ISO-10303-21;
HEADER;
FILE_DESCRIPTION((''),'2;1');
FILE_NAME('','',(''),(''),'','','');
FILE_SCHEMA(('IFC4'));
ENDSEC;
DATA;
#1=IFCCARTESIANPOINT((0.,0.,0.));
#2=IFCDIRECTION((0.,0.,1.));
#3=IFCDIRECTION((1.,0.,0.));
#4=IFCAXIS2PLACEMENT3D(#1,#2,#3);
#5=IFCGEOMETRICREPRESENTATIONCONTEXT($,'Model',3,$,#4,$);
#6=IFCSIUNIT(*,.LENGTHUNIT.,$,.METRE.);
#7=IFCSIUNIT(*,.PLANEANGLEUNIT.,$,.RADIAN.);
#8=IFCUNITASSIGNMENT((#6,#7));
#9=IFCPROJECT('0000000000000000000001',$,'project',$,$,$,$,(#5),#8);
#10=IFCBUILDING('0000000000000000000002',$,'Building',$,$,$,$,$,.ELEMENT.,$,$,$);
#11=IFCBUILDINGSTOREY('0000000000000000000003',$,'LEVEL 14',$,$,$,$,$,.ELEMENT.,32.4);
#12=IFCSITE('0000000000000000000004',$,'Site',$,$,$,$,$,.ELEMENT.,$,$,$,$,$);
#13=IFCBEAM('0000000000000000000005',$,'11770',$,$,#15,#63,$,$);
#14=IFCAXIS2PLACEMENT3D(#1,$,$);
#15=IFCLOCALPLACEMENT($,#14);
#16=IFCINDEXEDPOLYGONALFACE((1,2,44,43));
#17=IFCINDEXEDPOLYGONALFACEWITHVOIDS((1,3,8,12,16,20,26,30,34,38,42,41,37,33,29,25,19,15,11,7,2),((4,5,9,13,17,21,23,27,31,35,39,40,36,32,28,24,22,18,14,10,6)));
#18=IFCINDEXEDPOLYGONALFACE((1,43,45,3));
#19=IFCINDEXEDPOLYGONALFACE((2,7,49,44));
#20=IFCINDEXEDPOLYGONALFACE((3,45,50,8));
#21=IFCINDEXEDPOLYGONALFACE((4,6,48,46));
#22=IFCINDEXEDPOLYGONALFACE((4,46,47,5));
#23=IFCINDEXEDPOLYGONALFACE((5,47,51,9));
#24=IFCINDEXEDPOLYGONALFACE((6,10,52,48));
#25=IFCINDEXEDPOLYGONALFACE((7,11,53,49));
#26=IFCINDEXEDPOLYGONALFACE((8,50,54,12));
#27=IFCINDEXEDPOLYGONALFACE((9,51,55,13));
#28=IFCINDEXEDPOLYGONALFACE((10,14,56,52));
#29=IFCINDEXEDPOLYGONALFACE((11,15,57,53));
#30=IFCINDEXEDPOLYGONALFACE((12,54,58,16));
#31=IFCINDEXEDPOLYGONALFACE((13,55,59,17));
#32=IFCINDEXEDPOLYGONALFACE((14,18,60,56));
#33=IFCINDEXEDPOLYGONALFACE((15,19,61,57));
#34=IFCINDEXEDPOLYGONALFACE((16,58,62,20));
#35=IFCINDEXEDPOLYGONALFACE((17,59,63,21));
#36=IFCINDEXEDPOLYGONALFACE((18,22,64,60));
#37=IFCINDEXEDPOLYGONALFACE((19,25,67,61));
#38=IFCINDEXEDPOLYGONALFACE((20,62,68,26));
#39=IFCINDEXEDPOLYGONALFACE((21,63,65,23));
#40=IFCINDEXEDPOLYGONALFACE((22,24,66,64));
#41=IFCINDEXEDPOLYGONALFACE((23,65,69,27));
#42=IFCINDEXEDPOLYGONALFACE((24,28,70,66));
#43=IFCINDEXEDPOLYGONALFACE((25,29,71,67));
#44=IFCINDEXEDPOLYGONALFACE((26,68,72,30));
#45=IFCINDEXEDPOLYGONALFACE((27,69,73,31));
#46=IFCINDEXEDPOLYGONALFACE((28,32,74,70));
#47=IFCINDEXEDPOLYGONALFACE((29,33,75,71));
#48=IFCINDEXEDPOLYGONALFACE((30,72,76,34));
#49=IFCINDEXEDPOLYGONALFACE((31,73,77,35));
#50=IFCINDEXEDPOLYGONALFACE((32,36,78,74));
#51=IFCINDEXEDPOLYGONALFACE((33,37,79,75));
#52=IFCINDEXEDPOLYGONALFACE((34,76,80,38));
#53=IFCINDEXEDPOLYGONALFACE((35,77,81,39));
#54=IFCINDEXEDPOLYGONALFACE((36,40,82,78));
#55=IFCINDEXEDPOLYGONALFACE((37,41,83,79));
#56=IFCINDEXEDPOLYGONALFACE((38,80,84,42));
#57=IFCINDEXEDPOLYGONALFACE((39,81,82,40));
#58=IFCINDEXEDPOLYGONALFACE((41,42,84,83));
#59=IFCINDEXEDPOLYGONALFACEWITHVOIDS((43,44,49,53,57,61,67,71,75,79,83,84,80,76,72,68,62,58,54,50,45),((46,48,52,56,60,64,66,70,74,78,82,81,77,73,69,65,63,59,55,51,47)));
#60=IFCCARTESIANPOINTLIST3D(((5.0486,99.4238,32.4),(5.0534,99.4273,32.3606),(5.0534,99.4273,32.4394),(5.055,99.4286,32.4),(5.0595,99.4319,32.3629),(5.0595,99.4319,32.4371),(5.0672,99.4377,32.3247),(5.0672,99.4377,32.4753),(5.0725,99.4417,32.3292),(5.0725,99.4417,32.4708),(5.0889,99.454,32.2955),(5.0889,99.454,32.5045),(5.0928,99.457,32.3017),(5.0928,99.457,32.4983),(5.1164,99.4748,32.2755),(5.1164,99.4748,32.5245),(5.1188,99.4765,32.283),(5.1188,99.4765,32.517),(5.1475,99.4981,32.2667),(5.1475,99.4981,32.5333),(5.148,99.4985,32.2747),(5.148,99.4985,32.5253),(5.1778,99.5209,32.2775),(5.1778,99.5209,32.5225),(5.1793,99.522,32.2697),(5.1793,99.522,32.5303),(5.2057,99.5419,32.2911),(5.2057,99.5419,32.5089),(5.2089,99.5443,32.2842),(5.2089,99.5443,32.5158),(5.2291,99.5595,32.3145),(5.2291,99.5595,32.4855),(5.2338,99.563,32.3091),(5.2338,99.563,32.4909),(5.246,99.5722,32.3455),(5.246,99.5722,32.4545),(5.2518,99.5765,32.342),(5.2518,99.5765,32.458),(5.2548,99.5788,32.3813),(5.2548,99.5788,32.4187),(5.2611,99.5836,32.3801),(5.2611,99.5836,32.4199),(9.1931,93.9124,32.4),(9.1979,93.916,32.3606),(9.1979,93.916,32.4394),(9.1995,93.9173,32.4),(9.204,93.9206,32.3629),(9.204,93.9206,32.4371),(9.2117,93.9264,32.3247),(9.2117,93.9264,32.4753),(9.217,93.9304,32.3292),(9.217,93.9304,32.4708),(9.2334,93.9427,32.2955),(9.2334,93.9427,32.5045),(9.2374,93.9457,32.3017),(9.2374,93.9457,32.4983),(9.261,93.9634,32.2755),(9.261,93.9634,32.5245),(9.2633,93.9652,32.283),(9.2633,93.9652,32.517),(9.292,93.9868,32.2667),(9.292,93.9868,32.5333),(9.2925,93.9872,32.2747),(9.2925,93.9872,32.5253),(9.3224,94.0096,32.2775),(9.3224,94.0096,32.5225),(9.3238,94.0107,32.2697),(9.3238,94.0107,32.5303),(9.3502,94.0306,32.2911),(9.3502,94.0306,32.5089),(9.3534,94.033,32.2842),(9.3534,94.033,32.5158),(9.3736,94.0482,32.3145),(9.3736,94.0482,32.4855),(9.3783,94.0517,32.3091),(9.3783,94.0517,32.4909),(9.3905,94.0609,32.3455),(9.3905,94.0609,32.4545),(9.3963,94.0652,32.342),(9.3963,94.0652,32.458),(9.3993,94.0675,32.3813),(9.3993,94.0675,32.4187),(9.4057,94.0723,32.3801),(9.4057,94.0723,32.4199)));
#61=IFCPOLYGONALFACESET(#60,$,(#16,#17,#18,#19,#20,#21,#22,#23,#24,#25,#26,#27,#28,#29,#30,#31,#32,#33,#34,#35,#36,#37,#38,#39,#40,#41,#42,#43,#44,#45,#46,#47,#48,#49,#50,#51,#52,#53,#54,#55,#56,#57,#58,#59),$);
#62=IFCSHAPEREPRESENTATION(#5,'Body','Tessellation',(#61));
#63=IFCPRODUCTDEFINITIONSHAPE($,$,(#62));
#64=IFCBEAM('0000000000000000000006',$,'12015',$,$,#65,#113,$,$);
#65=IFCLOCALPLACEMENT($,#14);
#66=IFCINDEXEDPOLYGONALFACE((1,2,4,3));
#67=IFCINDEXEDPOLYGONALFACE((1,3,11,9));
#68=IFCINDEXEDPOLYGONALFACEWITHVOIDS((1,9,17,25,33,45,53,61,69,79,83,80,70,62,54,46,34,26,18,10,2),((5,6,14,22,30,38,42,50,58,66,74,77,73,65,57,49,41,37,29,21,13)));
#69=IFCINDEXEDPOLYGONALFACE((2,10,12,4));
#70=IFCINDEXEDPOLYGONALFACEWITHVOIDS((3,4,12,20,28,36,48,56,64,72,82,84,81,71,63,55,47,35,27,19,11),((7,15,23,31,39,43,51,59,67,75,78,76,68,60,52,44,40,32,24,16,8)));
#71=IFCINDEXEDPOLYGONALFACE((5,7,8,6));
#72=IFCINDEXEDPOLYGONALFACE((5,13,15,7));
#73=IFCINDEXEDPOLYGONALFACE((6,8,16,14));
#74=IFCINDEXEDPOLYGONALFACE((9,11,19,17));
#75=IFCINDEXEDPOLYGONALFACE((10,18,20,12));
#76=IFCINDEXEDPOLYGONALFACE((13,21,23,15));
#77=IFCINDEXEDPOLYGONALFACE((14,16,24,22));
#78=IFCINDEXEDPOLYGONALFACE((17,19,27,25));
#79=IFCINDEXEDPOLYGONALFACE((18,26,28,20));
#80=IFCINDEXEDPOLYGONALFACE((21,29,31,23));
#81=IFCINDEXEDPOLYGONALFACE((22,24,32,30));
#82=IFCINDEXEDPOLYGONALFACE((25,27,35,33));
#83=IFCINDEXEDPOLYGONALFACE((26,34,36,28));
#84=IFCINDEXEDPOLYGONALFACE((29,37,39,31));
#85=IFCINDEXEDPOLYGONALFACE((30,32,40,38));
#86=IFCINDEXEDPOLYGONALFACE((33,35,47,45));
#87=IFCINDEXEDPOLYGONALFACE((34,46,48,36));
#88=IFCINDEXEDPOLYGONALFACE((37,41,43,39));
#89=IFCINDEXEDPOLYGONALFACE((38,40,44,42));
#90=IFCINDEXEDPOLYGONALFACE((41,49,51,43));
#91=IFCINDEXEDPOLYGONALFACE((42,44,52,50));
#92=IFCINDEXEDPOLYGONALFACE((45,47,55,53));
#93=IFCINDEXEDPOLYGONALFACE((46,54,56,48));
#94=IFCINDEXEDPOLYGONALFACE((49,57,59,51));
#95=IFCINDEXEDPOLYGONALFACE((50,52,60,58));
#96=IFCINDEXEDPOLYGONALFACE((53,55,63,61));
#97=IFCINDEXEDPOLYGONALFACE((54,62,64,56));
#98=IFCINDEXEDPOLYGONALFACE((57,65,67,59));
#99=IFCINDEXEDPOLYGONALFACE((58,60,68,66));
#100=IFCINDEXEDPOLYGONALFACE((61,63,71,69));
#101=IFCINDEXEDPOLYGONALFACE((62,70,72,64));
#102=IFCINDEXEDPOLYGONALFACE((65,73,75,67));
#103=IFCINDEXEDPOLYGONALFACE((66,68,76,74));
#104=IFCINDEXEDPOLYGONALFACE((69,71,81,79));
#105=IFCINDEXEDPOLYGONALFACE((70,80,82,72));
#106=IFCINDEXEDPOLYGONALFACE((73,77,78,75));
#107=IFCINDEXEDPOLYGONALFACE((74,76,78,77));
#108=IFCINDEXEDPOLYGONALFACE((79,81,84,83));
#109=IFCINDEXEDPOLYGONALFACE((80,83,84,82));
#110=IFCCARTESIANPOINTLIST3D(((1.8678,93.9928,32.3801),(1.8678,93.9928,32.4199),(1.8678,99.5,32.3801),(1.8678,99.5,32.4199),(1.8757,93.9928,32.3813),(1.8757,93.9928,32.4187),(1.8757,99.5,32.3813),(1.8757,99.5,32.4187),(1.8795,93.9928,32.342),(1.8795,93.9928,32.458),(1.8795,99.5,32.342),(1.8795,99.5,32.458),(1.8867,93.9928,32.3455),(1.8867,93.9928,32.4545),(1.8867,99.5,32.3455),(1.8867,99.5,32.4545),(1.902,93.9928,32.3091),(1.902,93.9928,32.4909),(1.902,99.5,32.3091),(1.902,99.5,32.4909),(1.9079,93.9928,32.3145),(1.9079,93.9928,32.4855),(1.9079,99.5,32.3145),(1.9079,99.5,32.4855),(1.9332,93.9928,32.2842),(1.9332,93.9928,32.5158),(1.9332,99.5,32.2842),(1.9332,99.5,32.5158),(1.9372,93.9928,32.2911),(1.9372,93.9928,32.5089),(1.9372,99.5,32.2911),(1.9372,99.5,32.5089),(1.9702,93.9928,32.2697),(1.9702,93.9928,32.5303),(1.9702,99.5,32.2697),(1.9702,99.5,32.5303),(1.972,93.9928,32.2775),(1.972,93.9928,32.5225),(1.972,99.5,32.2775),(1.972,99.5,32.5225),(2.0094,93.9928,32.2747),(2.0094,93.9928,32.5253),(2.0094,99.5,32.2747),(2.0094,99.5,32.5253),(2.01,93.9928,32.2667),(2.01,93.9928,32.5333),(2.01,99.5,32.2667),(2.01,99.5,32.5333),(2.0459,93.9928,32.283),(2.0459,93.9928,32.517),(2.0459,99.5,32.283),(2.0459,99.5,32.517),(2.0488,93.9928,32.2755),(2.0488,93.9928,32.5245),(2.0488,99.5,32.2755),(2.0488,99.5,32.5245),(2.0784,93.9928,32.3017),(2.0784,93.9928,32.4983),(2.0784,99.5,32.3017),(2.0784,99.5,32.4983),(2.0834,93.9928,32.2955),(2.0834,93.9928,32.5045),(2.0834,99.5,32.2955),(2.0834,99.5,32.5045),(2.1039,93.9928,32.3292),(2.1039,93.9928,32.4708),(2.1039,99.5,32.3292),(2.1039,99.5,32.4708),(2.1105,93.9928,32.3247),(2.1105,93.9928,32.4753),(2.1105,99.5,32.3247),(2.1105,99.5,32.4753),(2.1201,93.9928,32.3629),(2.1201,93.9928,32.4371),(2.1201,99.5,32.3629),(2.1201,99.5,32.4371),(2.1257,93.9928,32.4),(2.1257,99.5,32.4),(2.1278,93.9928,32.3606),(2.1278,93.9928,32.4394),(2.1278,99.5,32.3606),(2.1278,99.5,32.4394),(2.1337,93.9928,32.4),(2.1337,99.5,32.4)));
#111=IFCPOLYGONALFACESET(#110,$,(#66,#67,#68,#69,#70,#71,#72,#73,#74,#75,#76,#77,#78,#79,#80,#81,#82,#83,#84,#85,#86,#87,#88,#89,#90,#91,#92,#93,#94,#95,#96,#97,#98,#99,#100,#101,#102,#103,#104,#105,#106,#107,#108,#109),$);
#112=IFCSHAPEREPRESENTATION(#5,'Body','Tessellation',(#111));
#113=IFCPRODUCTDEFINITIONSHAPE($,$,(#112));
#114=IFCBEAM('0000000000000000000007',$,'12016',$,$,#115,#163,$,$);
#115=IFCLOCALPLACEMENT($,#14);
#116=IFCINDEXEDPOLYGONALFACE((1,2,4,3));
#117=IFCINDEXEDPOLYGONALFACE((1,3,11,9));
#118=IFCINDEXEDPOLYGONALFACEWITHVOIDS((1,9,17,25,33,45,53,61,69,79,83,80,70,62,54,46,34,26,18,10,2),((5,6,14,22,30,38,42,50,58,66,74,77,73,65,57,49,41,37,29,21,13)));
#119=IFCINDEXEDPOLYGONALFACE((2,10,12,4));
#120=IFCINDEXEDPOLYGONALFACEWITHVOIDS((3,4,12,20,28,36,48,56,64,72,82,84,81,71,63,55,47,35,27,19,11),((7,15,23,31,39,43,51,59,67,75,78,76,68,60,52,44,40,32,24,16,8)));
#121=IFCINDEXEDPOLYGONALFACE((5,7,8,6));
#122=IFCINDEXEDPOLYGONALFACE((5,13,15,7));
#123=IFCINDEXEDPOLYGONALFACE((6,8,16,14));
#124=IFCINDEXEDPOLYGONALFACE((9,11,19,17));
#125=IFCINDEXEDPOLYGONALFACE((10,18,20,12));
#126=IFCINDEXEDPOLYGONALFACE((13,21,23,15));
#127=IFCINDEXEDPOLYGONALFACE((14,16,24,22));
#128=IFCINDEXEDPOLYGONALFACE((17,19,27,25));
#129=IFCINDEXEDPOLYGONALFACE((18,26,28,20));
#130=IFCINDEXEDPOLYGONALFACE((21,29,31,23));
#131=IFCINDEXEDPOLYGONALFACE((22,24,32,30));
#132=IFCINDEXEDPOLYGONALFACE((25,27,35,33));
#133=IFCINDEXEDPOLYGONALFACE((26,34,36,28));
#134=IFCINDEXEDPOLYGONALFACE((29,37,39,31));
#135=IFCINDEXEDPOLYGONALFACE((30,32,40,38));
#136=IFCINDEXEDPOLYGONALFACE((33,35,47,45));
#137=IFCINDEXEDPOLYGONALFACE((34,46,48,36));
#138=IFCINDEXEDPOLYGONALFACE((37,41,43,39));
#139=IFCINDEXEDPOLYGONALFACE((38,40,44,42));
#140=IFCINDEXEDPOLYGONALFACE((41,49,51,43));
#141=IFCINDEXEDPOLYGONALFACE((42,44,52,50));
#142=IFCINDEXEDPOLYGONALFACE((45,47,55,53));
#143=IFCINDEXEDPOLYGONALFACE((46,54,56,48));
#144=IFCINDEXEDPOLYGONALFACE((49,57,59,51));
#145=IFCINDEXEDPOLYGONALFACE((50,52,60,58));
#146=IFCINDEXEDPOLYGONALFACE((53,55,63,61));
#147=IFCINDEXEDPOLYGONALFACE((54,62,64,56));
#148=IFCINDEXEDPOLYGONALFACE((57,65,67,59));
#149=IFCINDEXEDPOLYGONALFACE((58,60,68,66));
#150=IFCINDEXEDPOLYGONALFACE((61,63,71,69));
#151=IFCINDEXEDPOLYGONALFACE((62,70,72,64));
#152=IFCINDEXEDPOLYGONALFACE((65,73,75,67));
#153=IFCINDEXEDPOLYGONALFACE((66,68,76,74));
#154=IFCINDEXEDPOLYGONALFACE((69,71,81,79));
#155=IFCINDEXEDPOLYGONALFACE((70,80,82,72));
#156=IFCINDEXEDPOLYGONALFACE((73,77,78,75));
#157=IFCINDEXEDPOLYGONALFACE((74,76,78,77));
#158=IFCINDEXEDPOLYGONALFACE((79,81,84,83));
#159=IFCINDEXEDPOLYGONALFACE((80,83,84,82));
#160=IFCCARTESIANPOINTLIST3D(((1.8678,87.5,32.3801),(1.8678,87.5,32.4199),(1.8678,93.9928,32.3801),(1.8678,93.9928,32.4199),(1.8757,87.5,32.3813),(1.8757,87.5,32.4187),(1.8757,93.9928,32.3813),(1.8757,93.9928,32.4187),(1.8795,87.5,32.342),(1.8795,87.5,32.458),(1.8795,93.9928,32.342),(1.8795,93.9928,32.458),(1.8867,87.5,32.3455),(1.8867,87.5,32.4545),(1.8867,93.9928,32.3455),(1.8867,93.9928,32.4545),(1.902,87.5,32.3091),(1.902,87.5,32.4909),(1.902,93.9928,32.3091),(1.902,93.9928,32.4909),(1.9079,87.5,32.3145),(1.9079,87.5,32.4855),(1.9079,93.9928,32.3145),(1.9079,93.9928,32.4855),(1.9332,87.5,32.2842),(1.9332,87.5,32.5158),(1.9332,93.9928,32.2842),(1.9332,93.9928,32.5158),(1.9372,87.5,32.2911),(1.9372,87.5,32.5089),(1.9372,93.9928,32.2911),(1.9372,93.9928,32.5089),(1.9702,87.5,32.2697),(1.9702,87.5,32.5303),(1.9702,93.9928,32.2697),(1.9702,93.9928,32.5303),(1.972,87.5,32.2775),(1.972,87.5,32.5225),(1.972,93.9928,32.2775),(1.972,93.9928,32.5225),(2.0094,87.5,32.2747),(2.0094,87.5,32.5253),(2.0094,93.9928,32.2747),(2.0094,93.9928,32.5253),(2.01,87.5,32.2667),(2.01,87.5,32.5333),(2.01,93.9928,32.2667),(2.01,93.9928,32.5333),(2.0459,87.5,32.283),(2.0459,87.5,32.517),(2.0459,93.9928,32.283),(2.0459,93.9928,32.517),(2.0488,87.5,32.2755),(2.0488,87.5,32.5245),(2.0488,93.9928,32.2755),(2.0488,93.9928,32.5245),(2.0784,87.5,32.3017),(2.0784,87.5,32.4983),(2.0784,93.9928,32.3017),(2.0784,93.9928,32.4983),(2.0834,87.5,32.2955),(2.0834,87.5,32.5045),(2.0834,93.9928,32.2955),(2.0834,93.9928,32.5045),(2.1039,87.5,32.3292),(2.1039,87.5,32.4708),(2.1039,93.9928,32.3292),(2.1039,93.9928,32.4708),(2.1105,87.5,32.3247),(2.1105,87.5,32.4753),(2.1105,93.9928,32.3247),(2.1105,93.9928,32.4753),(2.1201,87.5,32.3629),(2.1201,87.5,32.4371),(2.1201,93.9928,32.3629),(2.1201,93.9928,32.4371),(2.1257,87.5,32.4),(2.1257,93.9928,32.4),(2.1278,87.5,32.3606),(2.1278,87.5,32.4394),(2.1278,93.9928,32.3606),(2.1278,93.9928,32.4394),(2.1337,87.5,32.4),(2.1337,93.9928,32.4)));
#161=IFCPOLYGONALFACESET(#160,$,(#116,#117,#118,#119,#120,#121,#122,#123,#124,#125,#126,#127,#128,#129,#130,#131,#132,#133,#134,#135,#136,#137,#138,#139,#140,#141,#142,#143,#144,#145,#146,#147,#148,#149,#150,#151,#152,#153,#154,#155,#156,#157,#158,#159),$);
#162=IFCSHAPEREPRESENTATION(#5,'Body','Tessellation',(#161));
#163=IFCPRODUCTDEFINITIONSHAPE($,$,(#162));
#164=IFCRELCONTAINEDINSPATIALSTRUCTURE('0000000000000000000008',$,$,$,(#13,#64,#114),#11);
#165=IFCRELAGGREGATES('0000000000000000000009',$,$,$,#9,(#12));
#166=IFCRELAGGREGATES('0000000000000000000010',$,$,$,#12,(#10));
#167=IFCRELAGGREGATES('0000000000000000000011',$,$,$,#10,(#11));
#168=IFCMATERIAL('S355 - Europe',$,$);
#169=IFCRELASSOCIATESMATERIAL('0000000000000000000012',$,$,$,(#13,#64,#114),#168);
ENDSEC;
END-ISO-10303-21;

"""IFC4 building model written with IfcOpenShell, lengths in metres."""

from ifc_helpers import new_model, si_unit, frame, origin_with_axes, origin_2d_with_axis, place, context, project, spatial, hollow_circle, extrude, material, material_profile, profile_set, profile_usage, element, save


model = new_model("IFC4")

# Units and contexts
model_context = context("Model", 3, world=origin_with_axes())
ifc_project = project(units=[si_unit("LENGTHUNIT", "METRE"), si_unit("PLANEANGLEUNIT", "RADIAN")], contexts=[model_context])

# Site, building, storey
site = spatial("IfcSite", under=ifc_project, Name="Site", CompositionType="ELEMENT")
building = spatial("IfcBuilding", under=site, Name="Building", CompositionType="ELEMENT")
storey = spatial("IfcBuildingStorey", under=building, Name="LEVEL 14", CompositionType="ELEMENT", Elevation=32.4)

# Shared definitions
ifc_material = material(Name="S355 - Europe")

# Beams
ifc_material_profile_1 = material_profile(ifc_material, hollow_circle(Radius=0.1337, WallThickness=0.008, at=origin_2d_with_axis()))
ifc_profile_set_1 = profile_set([ifc_material_profile_1])
ifc_profile_usage_1 = profile_usage(ifc_profile_set_1, cardinal=10)
beam_1_placement = place(None, frame((9.3, 93.9928, 32.4), z_axis=(-0.601023, 0.799232, 0.0), x_axis=(-0.798681, -0.601755, 0.0)))
element("IfcBeam", 1, at=beam_1_placement, inside=storey, material=ifc_profile_usage_1, Name="11770", context=model_context, shape_type="SweptSolid", body=[
    extrude(hollow_circle(Radius=0.1337, WallThickness=0.008, at=origin_2d_with_axis()), origin_with_axes(), (0.0, 0.0, 1.0), 6.8958),
])
ifc_material_profile_2 = material_profile(ifc_material, hollow_circle(Radius=0.1337, WallThickness=0.008, at=origin_2d_with_axis()))
ifc_profile_set_2 = profile_set([ifc_material_profile_2])
ifc_profile_usage_2 = profile_usage(ifc_profile_set_2, cardinal=10)
beam_2_placement = place(None, frame((2.0, 99.5, 32.4), z_axis=(0.0, -1.0, 0.0), x_axis=(1.0, 0.0, 0.0)))
element("IfcBeam", 2, at=beam_2_placement, inside=storey, material=ifc_profile_usage_2, Name="12015", context=model_context, shape_type="SweptSolid", body=[
    extrude(hollow_circle(Radius=0.1337, WallThickness=0.008, at=origin_2d_with_axis()), origin_with_axes(), (0.0, 0.0, 1.0), 5.5072),
])
ifc_material_profile_3 = material_profile(ifc_material, hollow_circle(Radius=0.1337, WallThickness=0.008, at=origin_2d_with_axis()))
ifc_profile_set_3 = profile_set([ifc_material_profile_3])
ifc_profile_usage_3 = profile_usage(ifc_profile_set_3, cardinal=10)
beam_3_placement = place(None, frame((2.0, 93.9928, 32.4), z_axis=(0.0, -1.0, 0.0), x_axis=(1.0, 0.0, 0.0)))
element("IfcBeam", 3, at=beam_3_placement, inside=storey, material=ifc_profile_usage_3, Name="12016", context=model_context, shape_type="SweptSolid", body=[
    extrude(hollow_circle(Radius=0.1337, WallThickness=0.008, at=origin_2d_with_axis()), origin_with_axes(), (0.0, 0.0, 1.0), 6.4928),
])

save(model, "model.ifc")
